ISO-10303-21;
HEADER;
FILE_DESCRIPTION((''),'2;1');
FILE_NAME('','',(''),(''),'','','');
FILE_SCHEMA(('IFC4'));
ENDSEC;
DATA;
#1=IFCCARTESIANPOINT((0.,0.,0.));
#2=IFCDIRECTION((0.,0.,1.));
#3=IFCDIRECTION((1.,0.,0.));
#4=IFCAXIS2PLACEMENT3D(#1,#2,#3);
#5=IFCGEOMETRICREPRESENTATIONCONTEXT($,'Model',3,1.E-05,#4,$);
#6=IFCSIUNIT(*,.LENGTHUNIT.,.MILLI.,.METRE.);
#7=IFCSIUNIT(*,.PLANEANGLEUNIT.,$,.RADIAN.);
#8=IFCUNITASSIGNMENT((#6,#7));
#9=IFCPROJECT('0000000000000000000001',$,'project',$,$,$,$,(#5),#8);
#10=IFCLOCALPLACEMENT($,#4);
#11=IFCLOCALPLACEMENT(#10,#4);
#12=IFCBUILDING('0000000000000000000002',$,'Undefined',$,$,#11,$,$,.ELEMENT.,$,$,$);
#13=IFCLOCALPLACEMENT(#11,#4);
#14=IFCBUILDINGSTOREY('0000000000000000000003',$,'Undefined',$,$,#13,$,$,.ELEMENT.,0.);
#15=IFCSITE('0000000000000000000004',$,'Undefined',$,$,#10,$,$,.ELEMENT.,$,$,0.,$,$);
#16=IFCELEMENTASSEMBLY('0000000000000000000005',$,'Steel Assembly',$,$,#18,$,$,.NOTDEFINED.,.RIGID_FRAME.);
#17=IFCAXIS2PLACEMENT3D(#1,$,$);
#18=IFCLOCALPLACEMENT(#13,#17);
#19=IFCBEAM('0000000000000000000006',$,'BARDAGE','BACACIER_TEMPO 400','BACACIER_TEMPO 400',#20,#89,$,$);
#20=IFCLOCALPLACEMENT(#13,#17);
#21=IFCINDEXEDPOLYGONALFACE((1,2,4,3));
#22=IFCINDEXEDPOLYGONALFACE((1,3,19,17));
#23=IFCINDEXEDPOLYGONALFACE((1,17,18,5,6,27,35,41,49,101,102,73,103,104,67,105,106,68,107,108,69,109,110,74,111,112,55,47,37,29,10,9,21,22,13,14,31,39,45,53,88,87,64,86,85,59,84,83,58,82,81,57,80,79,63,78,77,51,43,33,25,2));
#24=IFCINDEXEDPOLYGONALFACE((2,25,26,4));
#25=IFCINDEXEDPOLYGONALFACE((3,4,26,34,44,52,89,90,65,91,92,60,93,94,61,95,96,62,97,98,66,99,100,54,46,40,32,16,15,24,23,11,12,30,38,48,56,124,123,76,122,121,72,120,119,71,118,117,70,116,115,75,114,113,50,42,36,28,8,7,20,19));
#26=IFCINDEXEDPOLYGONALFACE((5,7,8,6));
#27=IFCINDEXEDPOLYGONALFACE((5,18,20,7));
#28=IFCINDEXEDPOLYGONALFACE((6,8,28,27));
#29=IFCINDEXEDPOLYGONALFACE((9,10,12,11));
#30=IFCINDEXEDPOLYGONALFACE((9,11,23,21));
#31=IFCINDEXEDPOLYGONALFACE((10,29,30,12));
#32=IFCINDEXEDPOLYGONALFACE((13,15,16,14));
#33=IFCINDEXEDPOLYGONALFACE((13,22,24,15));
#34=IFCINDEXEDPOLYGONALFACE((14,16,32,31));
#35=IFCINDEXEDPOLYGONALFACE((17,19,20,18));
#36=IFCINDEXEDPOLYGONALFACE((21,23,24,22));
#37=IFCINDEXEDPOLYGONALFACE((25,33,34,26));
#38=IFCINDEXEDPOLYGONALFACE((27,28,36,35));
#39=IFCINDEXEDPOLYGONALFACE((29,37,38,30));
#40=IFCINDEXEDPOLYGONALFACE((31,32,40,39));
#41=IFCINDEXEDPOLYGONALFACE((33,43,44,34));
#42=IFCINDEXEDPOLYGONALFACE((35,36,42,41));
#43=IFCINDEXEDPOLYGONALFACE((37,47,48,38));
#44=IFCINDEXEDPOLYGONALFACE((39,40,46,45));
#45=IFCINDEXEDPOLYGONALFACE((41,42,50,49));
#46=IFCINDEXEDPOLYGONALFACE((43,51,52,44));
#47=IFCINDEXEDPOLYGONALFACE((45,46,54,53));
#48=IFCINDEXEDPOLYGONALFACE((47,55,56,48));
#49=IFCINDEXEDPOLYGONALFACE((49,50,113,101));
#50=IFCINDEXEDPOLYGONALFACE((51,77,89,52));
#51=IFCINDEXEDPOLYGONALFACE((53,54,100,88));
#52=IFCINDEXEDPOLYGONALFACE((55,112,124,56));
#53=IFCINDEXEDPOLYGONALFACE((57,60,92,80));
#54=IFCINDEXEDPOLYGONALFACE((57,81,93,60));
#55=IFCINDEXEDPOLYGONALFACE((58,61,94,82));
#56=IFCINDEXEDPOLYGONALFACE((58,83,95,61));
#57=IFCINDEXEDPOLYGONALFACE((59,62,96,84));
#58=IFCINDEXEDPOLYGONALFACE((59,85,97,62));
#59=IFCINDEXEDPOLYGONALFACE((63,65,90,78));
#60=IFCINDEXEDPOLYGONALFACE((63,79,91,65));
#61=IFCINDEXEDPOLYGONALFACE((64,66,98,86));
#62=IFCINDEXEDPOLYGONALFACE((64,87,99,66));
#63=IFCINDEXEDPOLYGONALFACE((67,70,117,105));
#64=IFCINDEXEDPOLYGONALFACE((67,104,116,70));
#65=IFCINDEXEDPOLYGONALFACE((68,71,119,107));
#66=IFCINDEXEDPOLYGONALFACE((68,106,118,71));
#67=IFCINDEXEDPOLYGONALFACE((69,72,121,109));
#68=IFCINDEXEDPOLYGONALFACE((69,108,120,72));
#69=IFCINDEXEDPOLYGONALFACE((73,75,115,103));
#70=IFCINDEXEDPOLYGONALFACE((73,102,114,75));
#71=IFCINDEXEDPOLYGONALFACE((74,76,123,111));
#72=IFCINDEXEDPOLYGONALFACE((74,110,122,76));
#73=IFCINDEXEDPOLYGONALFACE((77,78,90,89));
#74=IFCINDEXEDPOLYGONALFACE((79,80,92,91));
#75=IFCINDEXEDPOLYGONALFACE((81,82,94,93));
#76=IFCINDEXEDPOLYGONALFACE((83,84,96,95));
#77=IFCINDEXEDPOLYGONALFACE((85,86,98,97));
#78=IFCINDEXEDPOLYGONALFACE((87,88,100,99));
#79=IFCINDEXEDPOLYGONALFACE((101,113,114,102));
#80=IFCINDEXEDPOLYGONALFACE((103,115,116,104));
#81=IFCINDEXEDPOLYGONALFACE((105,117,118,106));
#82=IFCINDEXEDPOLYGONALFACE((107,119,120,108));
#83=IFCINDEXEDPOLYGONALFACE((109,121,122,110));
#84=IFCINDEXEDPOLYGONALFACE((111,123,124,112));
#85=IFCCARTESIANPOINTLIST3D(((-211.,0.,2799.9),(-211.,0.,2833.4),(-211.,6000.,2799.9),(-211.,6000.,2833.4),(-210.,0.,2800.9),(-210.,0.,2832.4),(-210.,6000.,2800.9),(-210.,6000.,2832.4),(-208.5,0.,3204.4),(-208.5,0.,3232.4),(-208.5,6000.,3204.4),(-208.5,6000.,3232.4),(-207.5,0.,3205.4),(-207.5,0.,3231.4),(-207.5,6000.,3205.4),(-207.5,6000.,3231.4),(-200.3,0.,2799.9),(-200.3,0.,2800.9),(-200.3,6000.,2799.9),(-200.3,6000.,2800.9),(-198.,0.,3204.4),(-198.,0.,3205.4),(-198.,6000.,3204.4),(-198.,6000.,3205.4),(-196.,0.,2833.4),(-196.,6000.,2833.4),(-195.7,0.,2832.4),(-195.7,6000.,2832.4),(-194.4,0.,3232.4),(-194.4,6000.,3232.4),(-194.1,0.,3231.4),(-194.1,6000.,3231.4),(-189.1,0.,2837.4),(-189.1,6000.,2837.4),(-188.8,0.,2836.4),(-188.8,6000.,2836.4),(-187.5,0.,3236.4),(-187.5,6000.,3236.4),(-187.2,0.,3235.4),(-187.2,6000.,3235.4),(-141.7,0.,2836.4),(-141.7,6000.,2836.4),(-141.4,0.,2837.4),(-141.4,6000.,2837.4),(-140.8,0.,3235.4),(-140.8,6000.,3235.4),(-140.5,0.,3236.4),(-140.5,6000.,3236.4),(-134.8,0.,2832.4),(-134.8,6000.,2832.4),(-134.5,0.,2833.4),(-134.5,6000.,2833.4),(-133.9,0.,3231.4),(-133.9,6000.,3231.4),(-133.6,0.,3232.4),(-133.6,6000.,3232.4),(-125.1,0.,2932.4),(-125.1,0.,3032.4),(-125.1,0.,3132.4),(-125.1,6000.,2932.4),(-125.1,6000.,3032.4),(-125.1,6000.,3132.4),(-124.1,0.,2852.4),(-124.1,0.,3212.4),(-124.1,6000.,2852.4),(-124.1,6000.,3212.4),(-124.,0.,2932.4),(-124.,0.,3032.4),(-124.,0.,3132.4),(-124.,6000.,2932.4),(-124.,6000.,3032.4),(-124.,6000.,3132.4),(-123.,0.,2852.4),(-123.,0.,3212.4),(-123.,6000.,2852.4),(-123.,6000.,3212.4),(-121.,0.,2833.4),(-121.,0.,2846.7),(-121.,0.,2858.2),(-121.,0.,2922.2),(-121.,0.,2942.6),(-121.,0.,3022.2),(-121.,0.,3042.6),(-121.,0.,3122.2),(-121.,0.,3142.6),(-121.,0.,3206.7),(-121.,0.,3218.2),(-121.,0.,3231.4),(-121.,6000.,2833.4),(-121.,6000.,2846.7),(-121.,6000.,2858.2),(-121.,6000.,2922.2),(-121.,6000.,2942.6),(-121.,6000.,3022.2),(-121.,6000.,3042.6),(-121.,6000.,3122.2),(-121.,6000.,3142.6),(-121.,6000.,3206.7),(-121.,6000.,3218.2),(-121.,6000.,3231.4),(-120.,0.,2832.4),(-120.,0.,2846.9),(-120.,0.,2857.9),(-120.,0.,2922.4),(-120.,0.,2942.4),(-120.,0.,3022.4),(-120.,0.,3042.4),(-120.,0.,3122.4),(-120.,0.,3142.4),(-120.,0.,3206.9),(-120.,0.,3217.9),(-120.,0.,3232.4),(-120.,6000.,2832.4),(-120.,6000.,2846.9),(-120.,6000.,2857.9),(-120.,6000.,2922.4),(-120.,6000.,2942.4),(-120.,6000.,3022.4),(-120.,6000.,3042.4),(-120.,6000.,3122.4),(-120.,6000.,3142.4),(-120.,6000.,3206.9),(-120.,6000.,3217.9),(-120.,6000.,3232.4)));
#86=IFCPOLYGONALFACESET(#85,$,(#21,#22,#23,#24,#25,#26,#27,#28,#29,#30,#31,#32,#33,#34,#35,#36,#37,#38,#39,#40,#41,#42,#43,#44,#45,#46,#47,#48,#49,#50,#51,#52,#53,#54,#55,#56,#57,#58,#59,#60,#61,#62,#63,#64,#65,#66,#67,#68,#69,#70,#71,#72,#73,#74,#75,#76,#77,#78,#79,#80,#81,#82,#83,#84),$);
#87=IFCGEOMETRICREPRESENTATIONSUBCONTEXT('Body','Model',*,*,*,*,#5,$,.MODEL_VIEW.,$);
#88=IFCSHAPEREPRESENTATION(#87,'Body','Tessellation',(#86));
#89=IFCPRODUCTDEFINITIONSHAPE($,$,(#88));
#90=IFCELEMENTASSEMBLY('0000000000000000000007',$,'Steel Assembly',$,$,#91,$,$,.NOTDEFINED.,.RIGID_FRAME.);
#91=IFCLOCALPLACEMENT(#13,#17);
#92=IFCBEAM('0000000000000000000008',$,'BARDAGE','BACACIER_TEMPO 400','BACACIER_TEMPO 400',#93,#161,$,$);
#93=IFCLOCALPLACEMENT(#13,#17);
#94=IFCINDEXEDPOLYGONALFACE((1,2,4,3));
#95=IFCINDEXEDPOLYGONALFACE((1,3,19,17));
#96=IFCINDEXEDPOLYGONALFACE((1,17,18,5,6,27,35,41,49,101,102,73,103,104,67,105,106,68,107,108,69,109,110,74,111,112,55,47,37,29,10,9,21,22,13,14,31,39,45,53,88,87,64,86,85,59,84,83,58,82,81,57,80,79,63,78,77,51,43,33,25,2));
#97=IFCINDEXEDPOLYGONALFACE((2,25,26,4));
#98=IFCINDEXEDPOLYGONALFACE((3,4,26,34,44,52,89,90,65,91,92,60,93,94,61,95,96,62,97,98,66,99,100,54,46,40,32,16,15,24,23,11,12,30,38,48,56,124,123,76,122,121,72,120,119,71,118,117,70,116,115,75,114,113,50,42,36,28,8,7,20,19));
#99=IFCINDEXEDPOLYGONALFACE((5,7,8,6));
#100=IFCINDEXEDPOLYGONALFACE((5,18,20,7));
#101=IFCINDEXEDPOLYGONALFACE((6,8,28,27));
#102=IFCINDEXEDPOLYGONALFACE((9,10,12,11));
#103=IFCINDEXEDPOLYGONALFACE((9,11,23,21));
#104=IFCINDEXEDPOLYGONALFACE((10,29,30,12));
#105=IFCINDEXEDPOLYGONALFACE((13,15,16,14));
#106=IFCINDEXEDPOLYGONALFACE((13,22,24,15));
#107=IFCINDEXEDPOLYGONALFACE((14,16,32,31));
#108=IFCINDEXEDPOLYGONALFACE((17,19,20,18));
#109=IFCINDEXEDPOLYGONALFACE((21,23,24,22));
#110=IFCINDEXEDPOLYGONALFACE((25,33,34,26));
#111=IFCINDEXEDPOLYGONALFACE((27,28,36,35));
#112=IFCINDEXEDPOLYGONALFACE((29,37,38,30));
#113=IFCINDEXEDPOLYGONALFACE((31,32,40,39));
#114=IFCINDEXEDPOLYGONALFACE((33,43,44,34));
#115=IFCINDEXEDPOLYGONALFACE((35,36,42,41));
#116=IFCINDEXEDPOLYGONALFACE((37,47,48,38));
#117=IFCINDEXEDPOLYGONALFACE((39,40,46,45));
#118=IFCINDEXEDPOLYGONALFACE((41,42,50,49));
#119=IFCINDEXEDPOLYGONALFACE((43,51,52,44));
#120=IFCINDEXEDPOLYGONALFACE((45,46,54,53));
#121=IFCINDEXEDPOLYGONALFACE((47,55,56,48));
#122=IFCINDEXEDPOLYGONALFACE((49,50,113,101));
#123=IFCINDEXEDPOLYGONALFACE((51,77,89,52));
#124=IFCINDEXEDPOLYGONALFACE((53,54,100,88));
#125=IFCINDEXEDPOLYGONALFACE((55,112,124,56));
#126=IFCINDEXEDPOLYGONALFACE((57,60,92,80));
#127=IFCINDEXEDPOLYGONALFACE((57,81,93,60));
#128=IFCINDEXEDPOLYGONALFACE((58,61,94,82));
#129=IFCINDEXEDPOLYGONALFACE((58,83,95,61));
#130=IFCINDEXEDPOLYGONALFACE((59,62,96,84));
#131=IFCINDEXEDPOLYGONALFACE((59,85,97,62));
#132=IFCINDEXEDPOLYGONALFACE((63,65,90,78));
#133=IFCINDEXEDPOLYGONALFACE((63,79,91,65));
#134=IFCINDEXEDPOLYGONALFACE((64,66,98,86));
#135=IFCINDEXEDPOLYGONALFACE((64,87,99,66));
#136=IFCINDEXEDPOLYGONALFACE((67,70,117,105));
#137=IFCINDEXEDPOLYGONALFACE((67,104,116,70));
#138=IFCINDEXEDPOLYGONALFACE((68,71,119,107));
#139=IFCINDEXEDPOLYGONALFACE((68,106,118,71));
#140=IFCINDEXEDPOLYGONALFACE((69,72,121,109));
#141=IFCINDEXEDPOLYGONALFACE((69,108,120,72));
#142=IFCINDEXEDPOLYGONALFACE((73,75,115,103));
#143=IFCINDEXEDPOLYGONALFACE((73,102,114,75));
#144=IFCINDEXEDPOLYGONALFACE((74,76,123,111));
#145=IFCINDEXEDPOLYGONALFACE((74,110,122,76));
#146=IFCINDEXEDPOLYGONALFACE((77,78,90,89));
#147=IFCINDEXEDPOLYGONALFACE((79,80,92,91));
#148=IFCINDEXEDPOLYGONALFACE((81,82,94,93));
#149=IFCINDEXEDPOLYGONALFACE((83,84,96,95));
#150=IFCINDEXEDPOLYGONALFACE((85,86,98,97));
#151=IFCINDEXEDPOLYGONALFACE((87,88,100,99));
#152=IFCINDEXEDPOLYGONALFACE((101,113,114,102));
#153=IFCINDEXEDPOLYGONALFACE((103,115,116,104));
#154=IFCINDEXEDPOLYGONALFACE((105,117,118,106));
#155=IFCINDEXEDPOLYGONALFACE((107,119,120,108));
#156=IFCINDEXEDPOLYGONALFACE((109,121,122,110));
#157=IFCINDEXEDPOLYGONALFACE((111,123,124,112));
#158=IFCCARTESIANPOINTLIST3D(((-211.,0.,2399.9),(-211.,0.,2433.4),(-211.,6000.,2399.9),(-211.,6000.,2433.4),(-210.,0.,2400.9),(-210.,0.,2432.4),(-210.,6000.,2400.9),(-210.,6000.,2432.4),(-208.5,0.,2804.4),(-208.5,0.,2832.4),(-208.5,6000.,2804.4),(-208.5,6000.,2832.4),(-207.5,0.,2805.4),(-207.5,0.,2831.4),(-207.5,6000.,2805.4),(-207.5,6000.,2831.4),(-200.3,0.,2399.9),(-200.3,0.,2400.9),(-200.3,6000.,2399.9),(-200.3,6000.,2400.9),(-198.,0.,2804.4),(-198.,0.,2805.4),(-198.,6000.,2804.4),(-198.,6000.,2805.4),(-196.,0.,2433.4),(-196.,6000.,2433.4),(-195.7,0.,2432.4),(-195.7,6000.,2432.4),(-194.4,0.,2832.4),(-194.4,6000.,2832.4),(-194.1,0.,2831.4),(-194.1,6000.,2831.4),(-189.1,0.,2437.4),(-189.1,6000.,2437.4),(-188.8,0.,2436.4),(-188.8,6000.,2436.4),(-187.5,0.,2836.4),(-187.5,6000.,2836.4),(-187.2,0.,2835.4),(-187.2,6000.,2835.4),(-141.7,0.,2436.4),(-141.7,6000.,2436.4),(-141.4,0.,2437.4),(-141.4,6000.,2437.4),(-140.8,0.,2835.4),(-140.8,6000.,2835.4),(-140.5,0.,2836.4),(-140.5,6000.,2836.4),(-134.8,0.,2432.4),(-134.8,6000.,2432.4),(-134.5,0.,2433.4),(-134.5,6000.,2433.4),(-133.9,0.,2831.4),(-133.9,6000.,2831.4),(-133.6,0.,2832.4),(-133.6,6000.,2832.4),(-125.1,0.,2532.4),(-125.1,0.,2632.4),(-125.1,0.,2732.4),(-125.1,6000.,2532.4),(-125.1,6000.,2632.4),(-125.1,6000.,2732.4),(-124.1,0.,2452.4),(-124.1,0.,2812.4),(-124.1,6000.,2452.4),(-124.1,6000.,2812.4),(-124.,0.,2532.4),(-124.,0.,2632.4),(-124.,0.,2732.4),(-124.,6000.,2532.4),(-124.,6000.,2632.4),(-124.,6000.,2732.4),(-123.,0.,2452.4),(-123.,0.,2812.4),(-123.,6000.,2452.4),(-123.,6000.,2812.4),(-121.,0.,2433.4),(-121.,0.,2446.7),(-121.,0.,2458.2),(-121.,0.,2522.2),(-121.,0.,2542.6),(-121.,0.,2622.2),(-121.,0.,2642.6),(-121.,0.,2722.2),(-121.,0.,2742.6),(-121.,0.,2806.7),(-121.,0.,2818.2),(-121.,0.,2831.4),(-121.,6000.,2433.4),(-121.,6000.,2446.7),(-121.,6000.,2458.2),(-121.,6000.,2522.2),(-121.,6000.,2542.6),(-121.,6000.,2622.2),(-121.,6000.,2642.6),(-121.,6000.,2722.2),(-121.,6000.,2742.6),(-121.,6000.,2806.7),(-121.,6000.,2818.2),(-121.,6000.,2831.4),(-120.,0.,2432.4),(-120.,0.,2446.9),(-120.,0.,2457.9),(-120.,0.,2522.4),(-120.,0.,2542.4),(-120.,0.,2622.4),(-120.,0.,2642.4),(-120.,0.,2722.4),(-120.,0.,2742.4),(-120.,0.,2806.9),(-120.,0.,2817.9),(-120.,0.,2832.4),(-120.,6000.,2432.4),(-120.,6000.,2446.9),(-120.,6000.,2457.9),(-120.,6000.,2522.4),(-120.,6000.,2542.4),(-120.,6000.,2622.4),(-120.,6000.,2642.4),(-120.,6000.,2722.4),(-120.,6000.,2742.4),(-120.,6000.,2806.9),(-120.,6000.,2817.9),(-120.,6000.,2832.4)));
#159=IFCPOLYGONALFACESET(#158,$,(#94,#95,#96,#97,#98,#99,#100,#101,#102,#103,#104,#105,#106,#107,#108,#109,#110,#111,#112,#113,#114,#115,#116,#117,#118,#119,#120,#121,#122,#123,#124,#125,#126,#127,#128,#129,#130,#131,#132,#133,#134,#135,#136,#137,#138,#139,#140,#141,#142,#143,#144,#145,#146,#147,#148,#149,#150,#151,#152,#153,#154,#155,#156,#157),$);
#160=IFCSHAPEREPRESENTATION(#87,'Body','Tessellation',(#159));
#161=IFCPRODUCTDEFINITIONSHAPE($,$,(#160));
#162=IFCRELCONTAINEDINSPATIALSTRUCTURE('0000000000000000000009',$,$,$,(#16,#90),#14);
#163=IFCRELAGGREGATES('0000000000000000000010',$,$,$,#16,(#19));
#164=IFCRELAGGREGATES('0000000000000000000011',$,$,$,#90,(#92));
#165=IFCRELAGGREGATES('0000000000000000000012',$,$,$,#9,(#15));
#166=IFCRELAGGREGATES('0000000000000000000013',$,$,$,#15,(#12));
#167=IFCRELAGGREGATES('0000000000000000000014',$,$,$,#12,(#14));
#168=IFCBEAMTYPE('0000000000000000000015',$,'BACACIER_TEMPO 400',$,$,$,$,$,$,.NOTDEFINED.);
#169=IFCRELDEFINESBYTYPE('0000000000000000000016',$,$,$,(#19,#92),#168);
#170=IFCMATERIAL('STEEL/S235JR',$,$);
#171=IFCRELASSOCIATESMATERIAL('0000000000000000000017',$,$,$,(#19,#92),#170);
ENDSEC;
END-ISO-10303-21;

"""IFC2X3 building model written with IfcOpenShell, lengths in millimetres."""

from ifc_helpers import new_model, si_unit, frame, origin_with_axes, place, context, subcontext, project, spatial, polyline, outline, extrude, material, type_object, element, aggregate, save


model = new_model("IFC2X3")

# Units and contexts
model_context = context("Model", 3, precision=1e-05, world=origin_with_axes())
body_context = subcontext(model_context, "Body", "Model", "MODEL_VIEW")
ifc_project = project(units=[si_unit("LENGTHUNIT", "METRE", prefix="MILLI"), si_unit("PLANEANGLEUNIT", "RADIAN")], contexts=[model_context])

# Site, building, storey
site_placement = place(None, origin_with_axes())
site = spatial("IfcSite", under=ifc_project, at=site_placement, Name="Undefined", CompositionType="ELEMENT", RefElevation=0.0)
building_placement = place(site_placement, origin_with_axes())
building = spatial("IfcBuilding", under=site, at=building_placement, Name="Undefined", CompositionType="ELEMENT")
storey_placement = place(building_placement, origin_with_axes())
storey = spatial("IfcBuildingStorey", under=building, at=storey_placement, Name="Undefined", CompositionType="ELEMENT", Elevation=0.0)

# Element assemblies, beams
ifc_material_1 = material(Name="STEEL/S235JR")
beam_type_1 = type_object("IfcBeamType", Name="BACACIER_TEMPO 400", PredefinedType="NOTDEFINED")
assembly_1_placement = place(storey_placement, origin_with_axes())
assembly_1 = element("IfcElementAssembly", 1, at=assembly_1_placement, inside=storey, Name="Steel Assembly", AssemblyPlace="NOTDEFINED", PredefinedType="RIGID_FRAME")
beam_1_placement = place(assembly_1_placement, frame((-165.5, 0.0, 3018.2), z_axis=(-1.0, 0.0, 0.0), x_axis=(0.0, 1.0, 0.0)))
beam_1 = element("IfcBeam", 2, at=beam_1_placement, type_object=beam_type_1, material=ifc_material_1, Name="BARDAGE", Description="BACACIER_TEMPO 400", ObjectType="BACACIER_TEMPO 400", context=body_context, shape_type="SweptSolid", body=[
    extrude(outline(polyline([(218.2, -25.0), (214.2, -31.9), (214.2, -45.5), (199.8, -45.5), (194.2, -42.5), (188.8, -45.5), (124.2, -45.5), (114.2, -41.5), (104.2, -45.5), (24.2, -45.5), (14.2, -41.5), (4.2, -45.5), (-75.8, -45.5), (-85.8, -41.5), (-95.8, -45.5), (-160.2, -45.5), (-165.8, -42.5), (-171.2, -45.5), (-185.8, -45.5), (-185.8, -30.7), (-181.8, -23.8), (-181.8, 23.3), (-185.8, 30.2), (-185.8, 44.5), (-217.2, 44.5), (-217.2, 34.8), (-218.2, 34.8), (-218.2, 45.5), (-184.8, 45.5), (-184.8, 30.5), (-180.8, 23.6), (-180.8, -24.1), (-184.8, -31.0), (-184.8, -44.5), (-171.5, -44.5), (-165.8, -41.4), (-160.0, -44.5), (-95.9, -44.5), (-85.8, -40.4), (-75.6, -44.5), (4.1, -44.5), (14.2, -40.4), (24.4, -44.5), (104.1, -44.5), (114.2, -40.4), (124.4, -44.5), (188.5, -44.5), (194.2, -41.4), (200.0, -44.5), (213.2, -44.5), (213.2, -31.6), (217.2, -24.7), (217.2, 21.7), (213.2, 28.6), (213.2, 42.0), (187.2, 42.0), (187.2, 32.5), (186.2, 32.5), (186.2, 43.0), (214.2, 43.0), (214.2, 28.9), (218.2, 22.0), (218.2, -25.0)])), frame((6000.0, 0.0, 0.0), z_axis=(-1.0, 0.0, 0.0), x_axis=(0.0, -1.0, 0.0)), (0.0, 0.0, 1.0), 6000.0),
])
aggregate(assembly_1, [beam_1])
assembly_2_placement = place(storey_placement, origin_with_axes())
assembly_2 = element("IfcElementAssembly", 3, at=assembly_2_placement, inside=storey, Name="Steel Assembly", AssemblyPlace="NOTDEFINED", PredefinedType="RIGID_FRAME")
beam_2_placement = place(assembly_2_placement, frame((-165.5, 0.0, 2618.2), z_axis=(-1.0, 0.0, 0.0), x_axis=(0.0, 1.0, 0.0)))
beam_2 = element("IfcBeam", 4, at=beam_2_placement, type_object=beam_type_1, material=ifc_material_1, Name="BARDAGE", Description="BACACIER_TEMPO 400", ObjectType="BACACIER_TEMPO 400", context=body_context, shape_type="SweptSolid", body=[
    extrude(outline(polyline([(218.2, -25.0), (214.2, -31.9), (214.2, -45.5), (199.8, -45.5), (194.2, -42.5), (188.8, -45.5), (124.2, -45.5), (114.2, -41.5), (104.2, -45.5), (24.2, -45.5), (14.2, -41.5), (4.2, -45.5), (-75.8, -45.5), (-85.8, -41.5), (-95.8, -45.5), (-160.2, -45.5), (-165.8, -42.5), (-171.2, -45.5), (-185.8, -45.5), (-185.8, -30.7), (-181.8, -23.8), (-181.8, 23.3), (-185.8, 30.2), (-185.8, 44.5), (-217.2, 44.5), (-217.2, 34.8), (-218.2, 34.8), (-218.2, 45.5), (-184.8, 45.5), (-184.8, 30.5), (-180.8, 23.6), (-180.8, -24.1), (-184.8, -31.0), (-184.8, -44.5), (-171.5, -44.5), (-165.8, -41.4), (-160.0, -44.5), (-95.9, -44.5), (-85.8, -40.4), (-75.6, -44.5), (4.1, -44.5), (14.2, -40.4), (24.4, -44.5), (104.1, -44.5), (114.2, -40.4), (124.4, -44.5), (188.5, -44.5), (194.2, -41.4), (200.0, -44.5), (213.2, -44.5), (213.2, -31.6), (217.2, -24.7), (217.2, 21.7), (213.2, 28.6), (213.2, 42.0), (187.2, 42.0), (187.2, 32.5), (186.2, 32.5), (186.2, 43.0), (214.2, 43.0), (214.2, 28.9), (218.2, 22.0), (218.2, -25.0)])), frame((6000.0, 0.0, 0.0), z_axis=(-1.0, 0.0, 0.0), x_axis=(0.0, -1.0, 0.0)), (0.0, 0.0, 1.0), 6000.0),
])
aggregate(assembly_2, [beam_2])

save(model, "model.ifc")
